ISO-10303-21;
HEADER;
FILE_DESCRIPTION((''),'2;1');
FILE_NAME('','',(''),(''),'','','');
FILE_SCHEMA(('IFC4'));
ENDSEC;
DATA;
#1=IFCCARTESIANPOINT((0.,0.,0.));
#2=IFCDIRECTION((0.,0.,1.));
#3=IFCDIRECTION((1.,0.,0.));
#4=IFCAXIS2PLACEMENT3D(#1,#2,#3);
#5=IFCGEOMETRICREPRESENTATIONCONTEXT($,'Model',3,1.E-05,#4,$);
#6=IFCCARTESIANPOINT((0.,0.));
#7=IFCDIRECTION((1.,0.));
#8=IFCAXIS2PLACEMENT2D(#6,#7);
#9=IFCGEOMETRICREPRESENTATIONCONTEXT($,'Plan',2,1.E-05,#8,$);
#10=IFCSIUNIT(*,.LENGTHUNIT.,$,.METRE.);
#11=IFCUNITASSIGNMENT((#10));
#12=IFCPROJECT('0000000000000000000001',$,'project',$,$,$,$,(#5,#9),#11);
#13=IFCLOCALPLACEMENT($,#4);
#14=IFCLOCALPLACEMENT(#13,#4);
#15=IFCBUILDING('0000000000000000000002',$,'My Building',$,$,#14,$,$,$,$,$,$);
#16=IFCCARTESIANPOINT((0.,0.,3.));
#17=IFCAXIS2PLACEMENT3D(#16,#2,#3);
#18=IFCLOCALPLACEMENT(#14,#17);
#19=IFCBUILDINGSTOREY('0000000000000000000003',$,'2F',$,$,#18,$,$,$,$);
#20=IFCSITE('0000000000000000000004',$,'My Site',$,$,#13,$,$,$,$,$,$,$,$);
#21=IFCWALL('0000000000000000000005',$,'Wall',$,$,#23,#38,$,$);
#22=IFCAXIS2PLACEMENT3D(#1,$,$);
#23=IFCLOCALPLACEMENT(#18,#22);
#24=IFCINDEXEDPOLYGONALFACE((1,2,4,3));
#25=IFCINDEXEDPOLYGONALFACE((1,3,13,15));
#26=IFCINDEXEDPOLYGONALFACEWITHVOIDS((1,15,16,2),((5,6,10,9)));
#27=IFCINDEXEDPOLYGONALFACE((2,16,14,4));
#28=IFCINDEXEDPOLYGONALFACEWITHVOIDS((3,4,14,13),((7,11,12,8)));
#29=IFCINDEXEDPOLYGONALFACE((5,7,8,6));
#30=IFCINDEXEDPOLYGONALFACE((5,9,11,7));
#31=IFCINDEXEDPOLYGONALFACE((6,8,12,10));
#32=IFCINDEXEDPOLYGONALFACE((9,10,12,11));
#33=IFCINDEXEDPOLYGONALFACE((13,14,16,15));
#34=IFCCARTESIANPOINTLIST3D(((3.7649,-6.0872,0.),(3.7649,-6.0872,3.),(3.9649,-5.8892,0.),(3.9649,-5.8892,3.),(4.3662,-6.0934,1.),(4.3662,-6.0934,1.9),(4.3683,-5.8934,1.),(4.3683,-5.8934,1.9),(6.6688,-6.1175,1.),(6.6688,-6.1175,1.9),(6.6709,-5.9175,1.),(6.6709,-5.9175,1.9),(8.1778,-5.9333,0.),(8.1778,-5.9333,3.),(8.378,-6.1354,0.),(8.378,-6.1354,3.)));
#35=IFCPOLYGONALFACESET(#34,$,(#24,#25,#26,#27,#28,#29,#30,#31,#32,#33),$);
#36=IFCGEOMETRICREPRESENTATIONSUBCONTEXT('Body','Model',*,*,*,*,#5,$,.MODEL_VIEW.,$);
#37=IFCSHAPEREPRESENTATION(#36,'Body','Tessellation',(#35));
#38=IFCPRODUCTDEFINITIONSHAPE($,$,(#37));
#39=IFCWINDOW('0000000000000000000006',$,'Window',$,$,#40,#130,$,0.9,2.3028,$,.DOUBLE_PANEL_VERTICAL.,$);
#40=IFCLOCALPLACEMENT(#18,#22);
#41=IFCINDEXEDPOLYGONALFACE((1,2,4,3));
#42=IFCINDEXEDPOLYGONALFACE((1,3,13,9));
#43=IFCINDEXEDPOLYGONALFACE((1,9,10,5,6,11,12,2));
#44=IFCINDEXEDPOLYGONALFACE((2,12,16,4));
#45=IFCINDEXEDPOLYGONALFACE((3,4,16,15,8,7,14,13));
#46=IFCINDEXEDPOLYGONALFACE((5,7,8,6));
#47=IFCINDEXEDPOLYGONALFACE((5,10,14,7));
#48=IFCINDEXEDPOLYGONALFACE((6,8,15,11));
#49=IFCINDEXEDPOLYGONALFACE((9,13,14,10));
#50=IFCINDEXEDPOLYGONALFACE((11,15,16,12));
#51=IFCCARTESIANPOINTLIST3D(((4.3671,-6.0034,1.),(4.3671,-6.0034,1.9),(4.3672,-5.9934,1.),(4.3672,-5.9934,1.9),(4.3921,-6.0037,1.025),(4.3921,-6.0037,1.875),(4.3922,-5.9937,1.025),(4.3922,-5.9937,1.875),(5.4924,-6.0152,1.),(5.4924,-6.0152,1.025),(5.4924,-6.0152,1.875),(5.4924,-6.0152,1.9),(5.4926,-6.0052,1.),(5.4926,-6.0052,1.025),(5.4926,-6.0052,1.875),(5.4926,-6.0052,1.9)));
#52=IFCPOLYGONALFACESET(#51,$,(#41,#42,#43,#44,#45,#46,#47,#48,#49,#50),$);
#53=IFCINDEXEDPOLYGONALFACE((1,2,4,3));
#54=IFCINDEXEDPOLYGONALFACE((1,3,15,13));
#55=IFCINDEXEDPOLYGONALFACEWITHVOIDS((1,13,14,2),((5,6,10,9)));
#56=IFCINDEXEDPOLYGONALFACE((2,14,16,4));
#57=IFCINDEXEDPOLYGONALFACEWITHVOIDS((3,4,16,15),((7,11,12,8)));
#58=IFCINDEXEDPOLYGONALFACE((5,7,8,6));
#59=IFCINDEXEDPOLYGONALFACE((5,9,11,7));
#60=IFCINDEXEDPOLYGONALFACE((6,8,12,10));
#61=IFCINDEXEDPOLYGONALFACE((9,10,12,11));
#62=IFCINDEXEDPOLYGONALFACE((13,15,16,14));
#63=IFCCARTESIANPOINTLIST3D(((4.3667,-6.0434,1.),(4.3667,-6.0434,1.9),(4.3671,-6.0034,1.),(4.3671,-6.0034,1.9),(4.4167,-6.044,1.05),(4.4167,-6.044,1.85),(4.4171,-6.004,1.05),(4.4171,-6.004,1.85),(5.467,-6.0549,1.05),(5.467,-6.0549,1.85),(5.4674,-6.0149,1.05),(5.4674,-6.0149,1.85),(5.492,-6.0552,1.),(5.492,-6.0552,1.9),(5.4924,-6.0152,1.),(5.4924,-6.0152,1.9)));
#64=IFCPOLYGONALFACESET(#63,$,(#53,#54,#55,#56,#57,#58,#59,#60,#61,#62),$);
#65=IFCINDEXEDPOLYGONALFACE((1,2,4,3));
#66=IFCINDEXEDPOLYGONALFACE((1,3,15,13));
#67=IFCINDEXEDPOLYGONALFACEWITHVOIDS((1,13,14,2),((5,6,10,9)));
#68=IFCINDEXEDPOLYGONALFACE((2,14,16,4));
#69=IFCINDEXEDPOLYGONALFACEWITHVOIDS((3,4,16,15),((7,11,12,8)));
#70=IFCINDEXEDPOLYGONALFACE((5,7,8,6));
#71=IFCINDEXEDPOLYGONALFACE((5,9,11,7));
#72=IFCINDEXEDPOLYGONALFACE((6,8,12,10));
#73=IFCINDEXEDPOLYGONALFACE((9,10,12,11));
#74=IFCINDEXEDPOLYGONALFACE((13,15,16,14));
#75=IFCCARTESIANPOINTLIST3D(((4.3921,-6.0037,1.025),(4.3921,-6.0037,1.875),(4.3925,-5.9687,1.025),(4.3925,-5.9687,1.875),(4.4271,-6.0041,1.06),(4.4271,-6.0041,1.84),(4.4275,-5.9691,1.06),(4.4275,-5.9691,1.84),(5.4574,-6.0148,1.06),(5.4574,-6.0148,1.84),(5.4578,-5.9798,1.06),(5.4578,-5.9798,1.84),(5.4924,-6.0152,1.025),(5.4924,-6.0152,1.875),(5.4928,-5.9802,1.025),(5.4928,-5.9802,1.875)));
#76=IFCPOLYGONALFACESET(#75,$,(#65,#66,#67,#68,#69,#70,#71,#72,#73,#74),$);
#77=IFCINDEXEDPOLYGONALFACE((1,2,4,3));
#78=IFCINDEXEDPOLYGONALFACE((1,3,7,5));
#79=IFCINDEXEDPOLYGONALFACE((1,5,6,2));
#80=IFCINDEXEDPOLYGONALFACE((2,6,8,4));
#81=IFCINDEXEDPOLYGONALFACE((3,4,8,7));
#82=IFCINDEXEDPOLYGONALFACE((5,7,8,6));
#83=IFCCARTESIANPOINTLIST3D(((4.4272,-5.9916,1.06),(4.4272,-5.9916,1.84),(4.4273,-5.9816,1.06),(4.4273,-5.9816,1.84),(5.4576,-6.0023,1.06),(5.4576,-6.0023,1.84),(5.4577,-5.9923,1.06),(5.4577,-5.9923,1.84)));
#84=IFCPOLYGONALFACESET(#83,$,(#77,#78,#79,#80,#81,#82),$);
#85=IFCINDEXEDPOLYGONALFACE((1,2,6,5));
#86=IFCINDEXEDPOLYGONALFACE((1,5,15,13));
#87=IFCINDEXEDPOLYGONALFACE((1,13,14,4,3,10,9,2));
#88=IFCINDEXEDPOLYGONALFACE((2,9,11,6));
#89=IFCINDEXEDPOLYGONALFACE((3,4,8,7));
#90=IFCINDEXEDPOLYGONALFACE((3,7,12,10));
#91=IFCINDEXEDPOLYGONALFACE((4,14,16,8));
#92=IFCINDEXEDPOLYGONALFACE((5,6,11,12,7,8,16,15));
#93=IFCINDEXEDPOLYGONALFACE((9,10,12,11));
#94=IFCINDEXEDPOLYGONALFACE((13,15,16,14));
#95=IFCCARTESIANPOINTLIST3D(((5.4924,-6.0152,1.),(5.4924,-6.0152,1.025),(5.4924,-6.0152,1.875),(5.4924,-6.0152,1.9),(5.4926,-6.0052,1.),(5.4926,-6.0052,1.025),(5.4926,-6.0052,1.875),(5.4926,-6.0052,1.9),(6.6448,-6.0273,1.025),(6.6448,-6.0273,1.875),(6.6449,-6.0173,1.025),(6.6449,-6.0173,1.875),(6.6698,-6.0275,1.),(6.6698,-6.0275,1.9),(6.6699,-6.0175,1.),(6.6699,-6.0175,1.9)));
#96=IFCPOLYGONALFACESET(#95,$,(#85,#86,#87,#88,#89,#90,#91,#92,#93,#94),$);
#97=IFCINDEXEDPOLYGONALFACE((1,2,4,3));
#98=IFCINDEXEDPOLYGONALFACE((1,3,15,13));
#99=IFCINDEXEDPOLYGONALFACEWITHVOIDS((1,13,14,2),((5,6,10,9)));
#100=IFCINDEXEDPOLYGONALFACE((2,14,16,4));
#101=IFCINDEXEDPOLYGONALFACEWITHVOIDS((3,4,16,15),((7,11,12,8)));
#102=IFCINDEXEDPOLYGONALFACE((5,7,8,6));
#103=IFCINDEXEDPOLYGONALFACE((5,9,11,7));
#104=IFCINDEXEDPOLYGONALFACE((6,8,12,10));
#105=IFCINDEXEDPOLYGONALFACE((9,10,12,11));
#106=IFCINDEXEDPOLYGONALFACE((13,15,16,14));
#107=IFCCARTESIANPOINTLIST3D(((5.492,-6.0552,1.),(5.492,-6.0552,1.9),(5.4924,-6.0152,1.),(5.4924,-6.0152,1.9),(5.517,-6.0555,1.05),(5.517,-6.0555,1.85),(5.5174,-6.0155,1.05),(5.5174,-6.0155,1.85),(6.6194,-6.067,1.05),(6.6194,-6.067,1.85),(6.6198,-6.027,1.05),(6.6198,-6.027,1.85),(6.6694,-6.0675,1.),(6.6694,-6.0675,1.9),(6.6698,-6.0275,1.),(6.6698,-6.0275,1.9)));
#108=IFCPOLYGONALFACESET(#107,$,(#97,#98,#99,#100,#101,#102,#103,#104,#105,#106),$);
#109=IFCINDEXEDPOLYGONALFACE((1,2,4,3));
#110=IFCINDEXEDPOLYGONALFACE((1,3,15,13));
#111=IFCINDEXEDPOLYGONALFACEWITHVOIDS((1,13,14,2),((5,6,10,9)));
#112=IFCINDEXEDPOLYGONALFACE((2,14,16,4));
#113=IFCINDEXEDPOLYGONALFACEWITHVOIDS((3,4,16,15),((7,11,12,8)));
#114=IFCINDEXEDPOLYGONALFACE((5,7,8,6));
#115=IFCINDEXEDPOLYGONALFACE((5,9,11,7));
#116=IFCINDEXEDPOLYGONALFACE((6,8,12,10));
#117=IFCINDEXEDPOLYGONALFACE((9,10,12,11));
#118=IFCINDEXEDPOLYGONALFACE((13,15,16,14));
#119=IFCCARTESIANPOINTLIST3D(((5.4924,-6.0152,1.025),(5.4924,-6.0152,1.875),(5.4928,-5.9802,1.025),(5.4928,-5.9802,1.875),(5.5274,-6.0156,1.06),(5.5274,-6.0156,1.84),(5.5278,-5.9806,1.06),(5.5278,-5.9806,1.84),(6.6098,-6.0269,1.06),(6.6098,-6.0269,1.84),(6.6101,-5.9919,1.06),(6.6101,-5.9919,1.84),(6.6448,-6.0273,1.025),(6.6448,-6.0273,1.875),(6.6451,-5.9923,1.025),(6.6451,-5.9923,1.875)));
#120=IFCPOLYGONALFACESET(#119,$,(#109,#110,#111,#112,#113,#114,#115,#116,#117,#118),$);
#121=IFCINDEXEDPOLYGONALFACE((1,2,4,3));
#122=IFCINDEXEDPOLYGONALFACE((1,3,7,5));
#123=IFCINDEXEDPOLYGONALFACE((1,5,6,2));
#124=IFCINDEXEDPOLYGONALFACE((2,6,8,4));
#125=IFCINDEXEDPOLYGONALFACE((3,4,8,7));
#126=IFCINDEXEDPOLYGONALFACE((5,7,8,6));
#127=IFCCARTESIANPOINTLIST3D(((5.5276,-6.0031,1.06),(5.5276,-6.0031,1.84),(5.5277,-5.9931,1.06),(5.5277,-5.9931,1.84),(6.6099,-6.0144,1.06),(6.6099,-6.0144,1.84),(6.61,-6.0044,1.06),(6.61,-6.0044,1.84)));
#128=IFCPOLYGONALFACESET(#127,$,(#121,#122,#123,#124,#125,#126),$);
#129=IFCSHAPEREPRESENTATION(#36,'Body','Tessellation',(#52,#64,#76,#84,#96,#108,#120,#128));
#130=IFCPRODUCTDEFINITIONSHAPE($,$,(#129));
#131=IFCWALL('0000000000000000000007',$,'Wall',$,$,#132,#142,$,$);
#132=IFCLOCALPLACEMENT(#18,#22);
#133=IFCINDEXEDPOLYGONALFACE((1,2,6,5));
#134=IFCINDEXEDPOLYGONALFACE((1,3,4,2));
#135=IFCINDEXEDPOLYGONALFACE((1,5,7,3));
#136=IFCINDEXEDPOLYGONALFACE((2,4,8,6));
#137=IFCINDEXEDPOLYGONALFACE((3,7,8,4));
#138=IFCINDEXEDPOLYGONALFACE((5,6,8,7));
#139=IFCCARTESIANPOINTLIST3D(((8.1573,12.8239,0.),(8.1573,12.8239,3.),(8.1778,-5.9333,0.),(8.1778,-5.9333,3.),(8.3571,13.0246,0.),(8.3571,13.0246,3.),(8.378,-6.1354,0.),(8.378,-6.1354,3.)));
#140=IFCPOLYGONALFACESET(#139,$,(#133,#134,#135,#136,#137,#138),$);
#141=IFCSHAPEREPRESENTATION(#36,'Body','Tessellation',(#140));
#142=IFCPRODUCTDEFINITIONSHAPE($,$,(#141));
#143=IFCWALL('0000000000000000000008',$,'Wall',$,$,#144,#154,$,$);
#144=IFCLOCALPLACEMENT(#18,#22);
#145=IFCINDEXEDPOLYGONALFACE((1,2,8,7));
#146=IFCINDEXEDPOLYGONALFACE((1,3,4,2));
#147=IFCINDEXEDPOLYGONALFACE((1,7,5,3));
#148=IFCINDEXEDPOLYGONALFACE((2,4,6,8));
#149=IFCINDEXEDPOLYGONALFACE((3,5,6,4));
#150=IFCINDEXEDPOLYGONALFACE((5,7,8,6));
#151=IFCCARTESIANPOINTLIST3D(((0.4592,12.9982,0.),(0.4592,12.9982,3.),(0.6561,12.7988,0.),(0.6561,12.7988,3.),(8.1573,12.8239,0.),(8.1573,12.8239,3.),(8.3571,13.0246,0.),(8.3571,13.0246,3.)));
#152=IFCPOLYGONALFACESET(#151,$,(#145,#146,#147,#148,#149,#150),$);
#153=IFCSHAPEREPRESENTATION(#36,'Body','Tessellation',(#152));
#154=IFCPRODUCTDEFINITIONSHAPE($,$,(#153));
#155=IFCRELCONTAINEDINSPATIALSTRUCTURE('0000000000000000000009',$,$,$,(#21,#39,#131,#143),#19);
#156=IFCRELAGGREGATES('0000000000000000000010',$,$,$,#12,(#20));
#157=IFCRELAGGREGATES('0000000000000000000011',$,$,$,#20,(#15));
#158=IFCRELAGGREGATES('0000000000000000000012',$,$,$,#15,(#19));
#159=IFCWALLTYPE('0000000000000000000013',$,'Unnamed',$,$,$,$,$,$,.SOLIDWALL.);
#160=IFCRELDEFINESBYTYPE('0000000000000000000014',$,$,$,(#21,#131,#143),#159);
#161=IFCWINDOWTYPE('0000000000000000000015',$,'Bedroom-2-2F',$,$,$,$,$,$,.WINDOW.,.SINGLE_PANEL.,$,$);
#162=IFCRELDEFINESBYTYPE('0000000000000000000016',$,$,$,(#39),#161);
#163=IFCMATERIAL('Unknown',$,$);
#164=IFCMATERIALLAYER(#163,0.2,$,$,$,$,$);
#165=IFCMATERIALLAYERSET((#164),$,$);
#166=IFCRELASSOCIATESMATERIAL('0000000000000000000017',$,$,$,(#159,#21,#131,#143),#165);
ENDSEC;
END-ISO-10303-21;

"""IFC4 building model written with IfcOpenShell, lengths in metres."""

from ifc_helpers import new_model, entity, si_unit, frame, origin_with_axes, origin_2d_with_axis, place, context, subcontext, project, spatial, line, indexed_curve, outline, extrude, shape, source, transform, mapped, material, layer, layer_set, layer_usage, type_object, type_shapes, element, fill, save


model = new_model("IFC4")

# Units and contexts
model_context = context("Model", 3, precision=1e-05, world=origin_with_axes())
plan_context = context("Plan", 2, precision=1e-05, world=origin_2d_with_axis())
body_context_1 = subcontext(model_context, "Body", "Model", "MODEL_VIEW")
body_context_2 = subcontext(plan_context, "Body", "Plan", "PLAN_VIEW")
ifc_project = project(units=[si_unit("LENGTHUNIT", "METRE")], contexts=[model_context, plan_context])

# Site, building, storey
site_placement = place(None, origin_with_axes())
site = spatial("IfcSite", under=ifc_project, at=site_placement, Name="My Site")
building_placement = place(site_placement, origin_with_axes())
building = spatial("IfcBuilding", under=site, at=building_placement, Name="My Building")
storey_placement = place(building_placement, frame((0.0, 0.0, 3.0), z_axis=(0.0, 0.0, 1.0), x_axis=(1.0, 0.0, 0.0)))
storey = spatial("IfcBuildingStorey", under=building, at=storey_placement, Name="2F")

# Shared definitions
ifc_material = material(Name="Unknown")

# Shared definitions
ifc_layer_1 = layer(ifc_material, 0.2)
ifc_layer_set_1 = layer_set([ifc_layer_1])
wall_type = type_object("IfcWallType", Name="Unnamed", PredefinedType="SOLIDWALL", material=ifc_layer_set_1)

# Wall, opening, window
ifc_layer_usage_1 = layer_usage(ifc_layer_set_1, "AXIS2", "POSITIVE", 0.0)
wall_1_placement = place(storey_placement, frame((3.7649, -6.0872, 0.0), z_axis=(0.0, 0.0, 1.0), x_axis=(0.999945, -0.010453, 0.0)))
wall_1 = element("IfcWall", 1, at=wall_1_placement, inside=storey, type_object=wall_type, material=ifc_layer_usage_1, Name="Wall", context=body_context_1, shape_type="SweptSolid", body=[
    extrude(outline(indexed_curve([(0.0, 0.0), (0.1979, 0.2), (4.4111, 0.2), (4.6134, 0.0)], segments=[line(1, 2, 3, 4, 1)])), origin_with_axes(), (0.0, 0.0, 1.0), 3.0),
])
shared_shape_1 = source(origin_with_axes(), body_context_1, "Body", "SweptSolid", [
    extrude(outline(indexed_curve([(0.0, 0.0), (2.3028, 0.0), (2.3028, 0.9), (0.0, 0.9)], segments=[line(1, 2, 3, 4, 1)])), frame((0.0, -0.6, 0.0), z_axis=(0.0, -1.0, 0.0), x_axis=(1.0, 0.0, 0.0)), (0.0, 0.0, -1.0), 1.2),
])
opening_1_placement = place(wall_1_placement, frame((0.6013, 0.0, 1.0), z_axis=(0.0, 0.0, 1.0), x_axis=(1.0, 0.0, 0.0)))
opening_1 = element("IfcOpeningElement", 2, at=opening_1_placement, cuts=wall_1, PredefinedType="OPENING", context=body_context_1, shape_type="MappedRepresentation", body=[
    mapped(shared_shape_1, transform((0.0, 0.0, 0.0), x_axis=(1.0, 0.0, 0.0), y_axis=(0.0, 1.0, 0.0), z_axis=(0.0, 0.0, 1.0), scale=1.0)),
])
window_type_1 = type_object("IfcWindowType", Name="Bedroom-2-2F", PartitioningType="SINGLE_PANEL", PredefinedType="WINDOW")
shared_shape_2 = source(origin_with_axes(), body_context_1, "Body", "SweptSolid", [
    extrude(outline(indexed_curve([(1.1254, 0.0), (0.0, 0.0), (0.0, 0.9), (1.1254, 0.9), (1.1254, 0.875), (0.025, 0.875), (0.025, 0.025), (1.1254, 0.025)], segments=[line(1, 2, 3, 4, 5, 6, 7, 8, 1)])), frame((0.0, 0.09, 0.0), z_axis=(0.0, -1.0, 0.0), x_axis=(1.0, 0.0, 0.0)), (0.0, 0.0, -1.0), 0.01),
    extrude(outline(indexed_curve([(0.0, 0.0), (1.1254, 0.0), (1.1254, 0.9), (0.0, 0.9)], segments=[line(1, 2, 3, 4, 1)]), holes=[indexed_curve([(0.05, 0.05), (1.1004, 0.05), (1.1004, 0.85), (0.05, 0.85)], segments=[line(1, 2, 3, 4, 1)])]), frame((0.0, 0.05, 0.0), z_axis=(0.0, -1.0, 0.0), x_axis=(1.0, 0.0, 0.0)), (0.0, 0.0, -1.0), 0.04),
    extrude(outline(indexed_curve([(0.0, 0.0), (1.1004, 0.0), (1.1004, 0.85), (0.0, 0.85)], segments=[line(1, 2, 3, 4, 1)]), holes=[indexed_curve([(0.035, 0.035), (1.0654, 0.035), (1.0654, 0.815), (0.035, 0.815)], segments=[line(1, 2, 3, 4, 1)])]), frame((0.025, 0.09, 0.025), z_axis=(0.0, -1.0, 0.0), x_axis=(1.0, 0.0, 0.0)), (0.0, 0.0, -1.0), 0.035),
    extrude(outline(indexed_curve([(0.035, 0.035), (1.0654, 0.035), (1.0654, 0.815), (0.035, 0.815)], segments=[line(1, 2, 3, 4, 1)])), frame((0.025, 0.1025, 0.025), z_axis=(0.0, -1.0, 0.0), x_axis=(1.0, 0.0, 0.0)), (0.0, 0.0, -1.0), 0.01),
    extrude(outline(indexed_curve([(0.0, 0.9), (1.1774, 0.9), (1.1774, 0.0), (0.0, 0.0), (0.0, 0.025), (1.1524, 0.025), (1.1524, 0.875), (0.0, 0.875)], segments=[line(1, 2, 3, 4, 5, 6, 7, 8, 1)])), frame((1.1254, 0.09, 0.0), z_axis=(0.0, -1.0, 0.0), x_axis=(1.0, 0.0, 0.0)), (0.0, 0.0, -1.0), 0.01),
    extrude(outline(indexed_curve([(0.0, 0.0), (1.1774, 0.0), (1.1774, 0.9), (0.0, 0.9)], segments=[line(1, 2, 3, 4, 1)]), holes=[indexed_curve([(0.025, 0.05), (1.1274, 0.05), (1.1274, 0.85), (0.025, 0.85)], segments=[line(1, 2, 3, 4, 1)])]), frame((1.1254, 0.05, 0.0), z_axis=(0.0, -1.0, 0.0), x_axis=(1.0, 0.0, 0.0)), (0.0, 0.0, -1.0), 0.04),
    extrude(outline(indexed_curve([(0.0, 0.0), (1.1524, 0.0), (1.1524, 0.85), (0.0, 0.85)], segments=[line(1, 2, 3, 4, 1)]), holes=[indexed_curve([(0.035, 0.035), (1.1174, 0.035), (1.1174, 0.815), (0.035, 0.815)], segments=[line(1, 2, 3, 4, 1)])]), frame((1.1254, 0.09, 0.025), z_axis=(0.0, -1.0, 0.0), x_axis=(1.0, 0.0, 0.0)), (0.0, 0.0, -1.0), 0.035),
    extrude(outline(indexed_curve([(0.035, 0.035), (1.1174, 0.035), (1.1174, 0.815), (0.035, 0.815)], segments=[line(1, 2, 3, 4, 1)])), frame((1.1254, 0.1025, 0.025), z_axis=(0.0, -1.0, 0.0), x_axis=(1.0, 0.0, 0.0)), (0.0, 0.0, -1.0), 0.01),
])
shared_shape_3 = source(origin_with_axes(), body_context_2, "Body", "Curve2D", [
    entity("IfcIndexedPolyCurve", entity("IfcCartesianPointList2D", [[0.05, 0.05], [1.1004, 0.05]])),
    entity("IfcIndexedPolyCurve", entity("IfcCartesianPointList2D", [[0.0, 0.1], [0.025, 0.1], [0.025, 0.09], [0.05, 0.09], [0.05, 0.05], [0.0, 0.05]]), [entity("IfcLineIndex", [1, 2, 3, 4, 5, 6, 1])]),
    entity("IfcIndexedPolyCurve", entity("IfcCartesianPointList2D", [[1.1254, 0.1], [1.1254, 0.1], [1.1254, 0.09], [1.1004, 0.09], [1.1004, 0.05], [1.1254, 0.05]])),
    entity("IfcIndexedPolyCurve", entity("IfcCartesianPointList2D", [[0.025, 0.09], [0.06, 0.09], [0.06, 0.125], [0.025, 0.125]]), [entity("IfcLineIndex", [1, 2, 3, 4, 1])]),
    entity("IfcIndexedPolyCurve", entity("IfcCartesianPointList2D", [[1.1254, 0.09], [1.0904, 0.09], [1.0904, 0.125], [1.1254, 0.125]]), [entity("IfcLineIndex", [1, 2, 3, 4, 1])]),
    entity("IfcIndexedPolyCurve", entity("IfcCartesianPointList2D", [[0.06, 0.09], [1.0904, 0.09]])),
    entity("IfcIndexedPolyCurve", entity("IfcCartesianPointList2D", [[0.06, 0.125], [1.0904, 0.125]])),
    entity("IfcIndexedPolyCurve", entity("IfcCartesianPointList2D", [[0.06, 0.1075], [1.0904, 0.1075]])),
    entity("IfcIndexedPolyCurve", entity("IfcCartesianPointList2D", [[1.1504, 0.05], [2.2528, 0.05]])),
    entity("IfcIndexedPolyCurve", entity("IfcCartesianPointList2D", [[1.1254, 0.1], [1.1254, 0.1], [1.1254, 0.09], [1.1504, 0.09], [1.1504, 0.05], [1.1254, 0.05]])),
    entity("IfcIndexedPolyCurve", entity("IfcCartesianPointList2D", [[2.3028, 0.1], [2.2778, 0.1], [2.2778, 0.09], [2.2528, 0.09], [2.2528, 0.05], [2.3028, 0.05]]), [entity("IfcLineIndex", [1, 2, 3, 4, 5, 6, 1])]),
    entity("IfcIndexedPolyCurve", entity("IfcCartesianPointList2D", [[1.1254, 0.09], [1.1604, 0.09], [1.1604, 0.125], [1.1254, 0.125]]), [entity("IfcLineIndex", [1, 2, 3, 4, 1])]),
    entity("IfcIndexedPolyCurve", entity("IfcCartesianPointList2D", [[2.2778, 0.09], [2.2428, 0.09], [2.2428, 0.125], [2.2778, 0.125]]), [entity("IfcLineIndex", [1, 2, 3, 4, 1])]),
    entity("IfcIndexedPolyCurve", entity("IfcCartesianPointList2D", [[1.1604, 0.09], [2.2428, 0.09]])),
    entity("IfcIndexedPolyCurve", entity("IfcCartesianPointList2D", [[1.1604, 0.125], [2.2428, 0.125]])),
    entity("IfcIndexedPolyCurve", entity("IfcCartesianPointList2D", [[1.1604, 0.1075], [2.2428, 0.1075]])),
])
type_shapes(window_type_1, [shared_shape_2, shared_shape_3])
window_1_placement = place(opening_1_placement, frame((0.0, 0.0, 0.0), z_axis=(0.0, 0.0, 1.0), x_axis=(1.0, 0.0, 0.0)))
window_1 = element("IfcWindow", 3, at=window_1_placement, inside=storey, type_object=window_type_1, Name="Window", OverallHeight=0.9, OverallWidth=2.3028, PartitioningType="DOUBLE_PANEL_VERTICAL", shapes=[
    shape(body_context_1, "Body", "MappedRepresentation", [mapped(shared_shape_2, transform((0.0, 0.0, 0.0), x_axis=(1.0, 0.0, 0.0), y_axis=(0.0, 1.0, 0.0), z_axis=(0.0, 0.0, 1.0), scale=1.0))]),
    shape(body_context_2, "Body", "MappedRepresentation", [mapped(shared_shape_3, transform((0.0, 0.0, 0.0), x_axis=(1.0, 0.0, 0.0), y_axis=(0.0, 1.0, 0.0), z_axis=(0.0, 0.0, 1.0), scale=1.0))]),
])
fill(opening_1, window_1)

# Walls
ifc_layer_usage_2 = layer_usage(ifc_layer_set_1, "AXIS2", "POSITIVE", 0.0)
wall_2_placement = place(storey_placement, frame((8.378, -6.1354, 0.0), z_axis=(0.0, 0.0, 1.0), x_axis=(-0.001091, 0.999999, 0.0)))
element("IfcWall", 4, at=wall_2_placement, inside=storey, type_object=wall_type, material=ifc_layer_usage_2, Name="Wall", context=body_context_1, shape_type="SweptSolid", body=[
    extrude(outline(indexed_curve([(0.0, 0.0), (0.2023, 0.2), (18.9595, 0.2), (19.1599, 0.0)], segments=[line(1, 2, 3, 4, 1)])), origin_with_axes(), (0.0, 0.0, 1.0), 3.0),
])
ifc_layer_usage_3 = layer_usage(ifc_layer_set_1, "AXIS2", "POSITIVE", 0.0)
wall_3_placement = place(storey_placement, frame((8.3571, 13.0246, 0.0), z_axis=(0.0, 0.0, 1.0), x_axis=(-0.999994, -0.00334, 0.0)))
element("IfcWall", 5, at=wall_3_placement, inside=storey, type_object=wall_type, material=ifc_layer_usage_3, Name="Wall", context=body_context_1, shape_type="SweptSolid", body=[
    extrude(outline(indexed_curve([(0.0, 0.0), (0.2005, 0.2), (7.7017, 0.2), (7.898, 0.0)], segments=[line(1, 2, 3, 4, 1)])), origin_with_axes(), (0.0, 0.0, 1.0), 3.0),
])

save(model, "model.ifc")
